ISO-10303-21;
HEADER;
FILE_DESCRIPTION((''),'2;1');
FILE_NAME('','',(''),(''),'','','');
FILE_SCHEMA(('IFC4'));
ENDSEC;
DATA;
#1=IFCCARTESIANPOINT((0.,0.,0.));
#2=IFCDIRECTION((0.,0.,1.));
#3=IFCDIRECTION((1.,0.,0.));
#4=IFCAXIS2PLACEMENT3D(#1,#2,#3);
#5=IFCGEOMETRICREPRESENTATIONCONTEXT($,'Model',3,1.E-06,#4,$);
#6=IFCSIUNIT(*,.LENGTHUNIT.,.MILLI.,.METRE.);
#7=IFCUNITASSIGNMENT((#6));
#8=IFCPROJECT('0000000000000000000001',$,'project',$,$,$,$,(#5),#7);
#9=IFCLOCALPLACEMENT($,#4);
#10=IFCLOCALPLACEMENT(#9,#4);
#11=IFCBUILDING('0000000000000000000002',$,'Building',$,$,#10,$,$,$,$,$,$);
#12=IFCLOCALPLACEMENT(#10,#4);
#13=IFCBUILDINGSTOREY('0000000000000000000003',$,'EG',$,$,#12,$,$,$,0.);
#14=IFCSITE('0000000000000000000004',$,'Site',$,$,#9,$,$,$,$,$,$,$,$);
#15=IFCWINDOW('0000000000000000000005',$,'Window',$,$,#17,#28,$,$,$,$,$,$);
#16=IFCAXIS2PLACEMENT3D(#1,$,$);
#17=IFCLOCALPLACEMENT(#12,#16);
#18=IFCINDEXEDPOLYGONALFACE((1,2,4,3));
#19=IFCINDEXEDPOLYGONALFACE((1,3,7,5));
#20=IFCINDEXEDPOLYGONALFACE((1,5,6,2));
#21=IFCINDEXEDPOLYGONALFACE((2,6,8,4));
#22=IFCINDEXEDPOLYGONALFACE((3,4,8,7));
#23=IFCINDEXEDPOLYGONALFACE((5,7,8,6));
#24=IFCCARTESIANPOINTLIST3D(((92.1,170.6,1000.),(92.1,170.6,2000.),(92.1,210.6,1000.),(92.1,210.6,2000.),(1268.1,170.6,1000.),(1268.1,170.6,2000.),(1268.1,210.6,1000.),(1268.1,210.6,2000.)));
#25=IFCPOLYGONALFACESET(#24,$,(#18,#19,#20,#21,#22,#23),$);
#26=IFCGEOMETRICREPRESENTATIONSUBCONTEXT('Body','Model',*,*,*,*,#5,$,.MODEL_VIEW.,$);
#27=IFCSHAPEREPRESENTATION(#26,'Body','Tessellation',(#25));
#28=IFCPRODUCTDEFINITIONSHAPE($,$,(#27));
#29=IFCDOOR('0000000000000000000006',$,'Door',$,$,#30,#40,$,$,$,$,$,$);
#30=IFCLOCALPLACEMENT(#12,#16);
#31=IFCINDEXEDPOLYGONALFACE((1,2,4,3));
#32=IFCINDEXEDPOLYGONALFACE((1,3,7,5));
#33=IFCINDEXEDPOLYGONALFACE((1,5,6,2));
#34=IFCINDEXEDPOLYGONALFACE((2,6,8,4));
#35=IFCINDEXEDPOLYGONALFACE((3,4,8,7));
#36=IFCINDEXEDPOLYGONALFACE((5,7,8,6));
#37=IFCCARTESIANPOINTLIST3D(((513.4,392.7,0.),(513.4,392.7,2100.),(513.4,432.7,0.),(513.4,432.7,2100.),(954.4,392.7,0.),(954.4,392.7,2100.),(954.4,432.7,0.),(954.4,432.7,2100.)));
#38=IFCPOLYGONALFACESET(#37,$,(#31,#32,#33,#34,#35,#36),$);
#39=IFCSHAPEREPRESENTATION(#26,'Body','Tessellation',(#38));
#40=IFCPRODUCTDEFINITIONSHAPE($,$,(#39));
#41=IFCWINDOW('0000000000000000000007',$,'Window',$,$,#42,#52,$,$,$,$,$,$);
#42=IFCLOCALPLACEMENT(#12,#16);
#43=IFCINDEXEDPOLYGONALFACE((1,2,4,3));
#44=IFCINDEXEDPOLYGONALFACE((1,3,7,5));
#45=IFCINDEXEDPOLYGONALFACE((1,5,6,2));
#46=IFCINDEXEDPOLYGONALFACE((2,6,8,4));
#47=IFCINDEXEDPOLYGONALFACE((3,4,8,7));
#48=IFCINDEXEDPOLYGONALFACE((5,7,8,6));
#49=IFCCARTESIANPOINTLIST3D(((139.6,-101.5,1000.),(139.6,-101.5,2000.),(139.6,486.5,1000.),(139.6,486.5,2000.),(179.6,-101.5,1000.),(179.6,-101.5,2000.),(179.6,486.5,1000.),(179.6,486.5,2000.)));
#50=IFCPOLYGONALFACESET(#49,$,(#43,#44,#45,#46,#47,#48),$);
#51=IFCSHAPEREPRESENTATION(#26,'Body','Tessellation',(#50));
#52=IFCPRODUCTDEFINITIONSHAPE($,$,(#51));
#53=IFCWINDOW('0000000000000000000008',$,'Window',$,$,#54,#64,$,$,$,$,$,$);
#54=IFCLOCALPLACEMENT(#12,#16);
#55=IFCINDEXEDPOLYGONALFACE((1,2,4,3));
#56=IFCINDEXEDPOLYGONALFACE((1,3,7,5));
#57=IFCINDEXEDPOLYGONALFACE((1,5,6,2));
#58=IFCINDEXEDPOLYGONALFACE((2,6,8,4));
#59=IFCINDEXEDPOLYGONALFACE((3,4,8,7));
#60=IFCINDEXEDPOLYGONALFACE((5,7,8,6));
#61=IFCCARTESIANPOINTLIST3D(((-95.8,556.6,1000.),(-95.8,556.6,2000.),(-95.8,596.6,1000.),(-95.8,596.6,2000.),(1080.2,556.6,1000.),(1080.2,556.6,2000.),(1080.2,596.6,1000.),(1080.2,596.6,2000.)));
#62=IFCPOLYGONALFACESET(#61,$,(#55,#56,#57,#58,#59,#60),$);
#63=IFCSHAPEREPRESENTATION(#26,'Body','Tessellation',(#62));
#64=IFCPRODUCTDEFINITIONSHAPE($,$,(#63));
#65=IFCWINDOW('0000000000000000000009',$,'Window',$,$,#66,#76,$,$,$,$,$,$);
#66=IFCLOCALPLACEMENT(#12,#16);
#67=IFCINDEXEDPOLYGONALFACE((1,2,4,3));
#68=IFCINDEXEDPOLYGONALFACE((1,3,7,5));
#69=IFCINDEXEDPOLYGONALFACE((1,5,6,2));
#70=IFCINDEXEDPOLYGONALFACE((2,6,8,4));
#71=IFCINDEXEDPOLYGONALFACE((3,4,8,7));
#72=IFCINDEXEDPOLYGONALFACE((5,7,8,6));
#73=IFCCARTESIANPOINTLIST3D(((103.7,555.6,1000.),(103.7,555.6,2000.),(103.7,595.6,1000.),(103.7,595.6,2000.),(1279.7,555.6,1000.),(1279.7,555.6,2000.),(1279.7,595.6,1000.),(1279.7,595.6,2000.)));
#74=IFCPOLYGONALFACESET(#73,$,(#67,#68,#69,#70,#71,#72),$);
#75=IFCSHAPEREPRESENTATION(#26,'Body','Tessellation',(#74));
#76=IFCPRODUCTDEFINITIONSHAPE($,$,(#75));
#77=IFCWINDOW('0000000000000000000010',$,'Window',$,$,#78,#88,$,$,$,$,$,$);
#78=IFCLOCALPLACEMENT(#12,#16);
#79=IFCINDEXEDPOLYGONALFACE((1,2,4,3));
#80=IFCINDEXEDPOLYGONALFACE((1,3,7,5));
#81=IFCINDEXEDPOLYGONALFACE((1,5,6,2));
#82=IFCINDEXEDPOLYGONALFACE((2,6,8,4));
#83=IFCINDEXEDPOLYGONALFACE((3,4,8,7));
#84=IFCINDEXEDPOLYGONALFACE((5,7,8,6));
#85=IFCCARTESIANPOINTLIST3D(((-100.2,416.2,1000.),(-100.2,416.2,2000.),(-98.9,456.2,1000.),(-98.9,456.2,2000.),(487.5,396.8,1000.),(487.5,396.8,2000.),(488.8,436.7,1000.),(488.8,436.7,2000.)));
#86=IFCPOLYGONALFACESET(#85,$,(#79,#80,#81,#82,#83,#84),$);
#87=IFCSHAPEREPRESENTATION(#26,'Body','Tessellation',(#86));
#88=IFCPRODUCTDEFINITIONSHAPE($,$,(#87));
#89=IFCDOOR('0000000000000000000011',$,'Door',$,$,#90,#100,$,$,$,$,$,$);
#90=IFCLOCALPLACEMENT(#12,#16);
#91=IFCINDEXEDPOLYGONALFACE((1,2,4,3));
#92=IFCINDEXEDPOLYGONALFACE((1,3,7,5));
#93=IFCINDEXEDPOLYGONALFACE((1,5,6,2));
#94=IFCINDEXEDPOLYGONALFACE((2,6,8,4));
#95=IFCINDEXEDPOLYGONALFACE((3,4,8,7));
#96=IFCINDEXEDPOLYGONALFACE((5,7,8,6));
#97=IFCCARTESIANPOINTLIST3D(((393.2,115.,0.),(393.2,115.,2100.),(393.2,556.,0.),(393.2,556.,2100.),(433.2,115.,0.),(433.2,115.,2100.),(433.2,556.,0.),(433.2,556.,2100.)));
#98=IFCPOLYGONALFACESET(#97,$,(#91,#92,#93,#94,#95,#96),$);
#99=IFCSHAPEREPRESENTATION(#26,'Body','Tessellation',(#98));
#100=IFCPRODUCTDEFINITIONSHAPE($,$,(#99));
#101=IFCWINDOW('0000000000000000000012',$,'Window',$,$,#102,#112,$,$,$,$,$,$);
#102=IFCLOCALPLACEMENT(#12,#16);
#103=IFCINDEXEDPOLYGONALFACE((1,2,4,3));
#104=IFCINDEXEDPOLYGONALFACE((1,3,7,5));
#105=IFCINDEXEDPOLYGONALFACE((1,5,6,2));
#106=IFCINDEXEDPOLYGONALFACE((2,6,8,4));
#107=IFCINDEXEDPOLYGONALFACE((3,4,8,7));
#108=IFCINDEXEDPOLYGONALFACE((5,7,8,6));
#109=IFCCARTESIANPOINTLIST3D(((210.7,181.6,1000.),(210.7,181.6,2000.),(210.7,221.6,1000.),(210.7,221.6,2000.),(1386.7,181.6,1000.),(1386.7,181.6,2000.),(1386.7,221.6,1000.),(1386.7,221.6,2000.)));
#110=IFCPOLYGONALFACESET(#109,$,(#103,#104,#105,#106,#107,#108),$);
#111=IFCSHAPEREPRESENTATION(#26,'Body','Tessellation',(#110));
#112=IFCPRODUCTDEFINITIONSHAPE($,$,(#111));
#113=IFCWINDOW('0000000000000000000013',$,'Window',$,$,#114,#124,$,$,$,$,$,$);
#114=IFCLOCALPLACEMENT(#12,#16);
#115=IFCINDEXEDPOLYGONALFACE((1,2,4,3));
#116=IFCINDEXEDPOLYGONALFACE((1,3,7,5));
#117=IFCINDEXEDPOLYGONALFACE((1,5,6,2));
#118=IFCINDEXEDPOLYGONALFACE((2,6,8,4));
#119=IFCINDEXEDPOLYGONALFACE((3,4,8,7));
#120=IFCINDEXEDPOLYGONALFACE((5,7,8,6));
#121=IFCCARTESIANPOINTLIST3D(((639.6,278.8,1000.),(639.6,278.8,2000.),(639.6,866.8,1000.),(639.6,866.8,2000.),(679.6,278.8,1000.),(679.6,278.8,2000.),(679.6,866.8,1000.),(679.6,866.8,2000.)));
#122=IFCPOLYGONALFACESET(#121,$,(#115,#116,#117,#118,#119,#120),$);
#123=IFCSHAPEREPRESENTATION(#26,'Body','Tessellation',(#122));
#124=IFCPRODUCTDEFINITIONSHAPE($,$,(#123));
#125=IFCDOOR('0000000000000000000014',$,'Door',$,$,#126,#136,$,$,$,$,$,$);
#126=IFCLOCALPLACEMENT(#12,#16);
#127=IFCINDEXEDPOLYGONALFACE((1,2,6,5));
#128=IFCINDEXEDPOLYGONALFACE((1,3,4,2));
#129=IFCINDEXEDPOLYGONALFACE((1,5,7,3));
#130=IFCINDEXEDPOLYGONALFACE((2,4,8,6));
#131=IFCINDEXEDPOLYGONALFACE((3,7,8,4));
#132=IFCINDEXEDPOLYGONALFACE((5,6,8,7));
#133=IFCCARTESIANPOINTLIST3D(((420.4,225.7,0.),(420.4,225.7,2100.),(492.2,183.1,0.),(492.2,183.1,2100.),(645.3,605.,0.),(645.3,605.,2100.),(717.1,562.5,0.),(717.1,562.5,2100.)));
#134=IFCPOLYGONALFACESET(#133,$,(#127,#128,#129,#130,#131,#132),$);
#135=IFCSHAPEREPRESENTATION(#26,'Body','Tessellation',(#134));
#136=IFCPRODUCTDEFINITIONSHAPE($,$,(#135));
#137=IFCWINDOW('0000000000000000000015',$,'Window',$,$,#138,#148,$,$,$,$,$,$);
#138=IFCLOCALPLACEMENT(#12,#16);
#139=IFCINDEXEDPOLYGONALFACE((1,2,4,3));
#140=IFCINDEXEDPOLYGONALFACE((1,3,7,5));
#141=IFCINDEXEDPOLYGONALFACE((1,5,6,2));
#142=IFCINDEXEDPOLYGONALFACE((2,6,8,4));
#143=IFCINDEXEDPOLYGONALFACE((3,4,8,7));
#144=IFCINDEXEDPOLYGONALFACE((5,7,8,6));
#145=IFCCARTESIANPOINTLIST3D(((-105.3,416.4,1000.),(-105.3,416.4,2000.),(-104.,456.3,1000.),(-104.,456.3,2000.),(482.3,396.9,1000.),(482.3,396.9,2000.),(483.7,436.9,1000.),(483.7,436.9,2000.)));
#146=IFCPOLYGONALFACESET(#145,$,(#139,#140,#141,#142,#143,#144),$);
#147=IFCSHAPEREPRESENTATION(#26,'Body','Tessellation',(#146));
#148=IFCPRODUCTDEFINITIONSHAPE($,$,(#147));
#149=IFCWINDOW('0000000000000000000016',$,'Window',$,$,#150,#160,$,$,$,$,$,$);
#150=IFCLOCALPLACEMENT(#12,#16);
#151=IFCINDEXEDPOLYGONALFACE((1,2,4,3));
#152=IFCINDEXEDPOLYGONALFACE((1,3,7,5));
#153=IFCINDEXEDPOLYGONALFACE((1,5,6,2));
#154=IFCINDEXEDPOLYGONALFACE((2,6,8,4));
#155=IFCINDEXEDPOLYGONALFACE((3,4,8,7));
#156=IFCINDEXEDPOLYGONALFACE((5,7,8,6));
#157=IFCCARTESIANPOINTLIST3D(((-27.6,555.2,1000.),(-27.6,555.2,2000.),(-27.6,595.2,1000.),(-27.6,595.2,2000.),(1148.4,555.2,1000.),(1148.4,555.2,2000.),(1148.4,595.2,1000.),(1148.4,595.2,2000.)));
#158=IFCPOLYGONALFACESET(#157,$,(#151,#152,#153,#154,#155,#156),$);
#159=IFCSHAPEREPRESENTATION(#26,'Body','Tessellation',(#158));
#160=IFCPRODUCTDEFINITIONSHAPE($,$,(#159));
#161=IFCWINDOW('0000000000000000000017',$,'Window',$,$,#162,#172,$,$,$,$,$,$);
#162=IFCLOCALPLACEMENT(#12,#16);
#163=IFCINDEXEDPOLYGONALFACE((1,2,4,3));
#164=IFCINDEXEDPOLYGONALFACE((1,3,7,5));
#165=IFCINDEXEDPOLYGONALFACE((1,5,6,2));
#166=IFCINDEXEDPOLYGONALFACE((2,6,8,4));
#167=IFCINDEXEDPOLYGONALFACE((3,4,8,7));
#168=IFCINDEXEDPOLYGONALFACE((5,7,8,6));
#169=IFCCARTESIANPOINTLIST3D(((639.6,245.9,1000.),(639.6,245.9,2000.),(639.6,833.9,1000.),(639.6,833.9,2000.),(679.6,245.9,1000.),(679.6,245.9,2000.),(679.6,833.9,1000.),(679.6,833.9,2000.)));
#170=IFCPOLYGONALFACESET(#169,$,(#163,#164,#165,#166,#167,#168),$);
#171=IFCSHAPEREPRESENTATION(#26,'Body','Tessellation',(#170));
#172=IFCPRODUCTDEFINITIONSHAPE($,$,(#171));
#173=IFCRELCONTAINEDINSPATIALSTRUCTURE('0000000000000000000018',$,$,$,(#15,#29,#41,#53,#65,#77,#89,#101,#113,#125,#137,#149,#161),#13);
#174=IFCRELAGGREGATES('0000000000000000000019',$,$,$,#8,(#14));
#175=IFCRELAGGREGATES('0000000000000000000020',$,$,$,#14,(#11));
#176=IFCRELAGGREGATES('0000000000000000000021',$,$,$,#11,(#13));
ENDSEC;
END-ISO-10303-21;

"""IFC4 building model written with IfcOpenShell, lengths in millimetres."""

from ifc_helpers import new_model, si_unit, frame, origin_with_axes, place, context, subcontext, project, spatial, rectangle, extrude, element, save


model = new_model("IFC4")

# Units and contexts
model_context = context("Model", 3, precision=1e-06, world=origin_with_axes())
body_context = subcontext(model_context, "Body", "Model", "MODEL_VIEW")
ifc_project = project(units=[si_unit("LENGTHUNIT", "METRE", prefix="MILLI")], contexts=[model_context])

# Site, building, storey
site_placement = place(None, origin_with_axes())
site = spatial("IfcSite", under=ifc_project, at=site_placement, Name="Site")
building_placement = place(site_placement, origin_with_axes())
building = spatial("IfcBuilding", under=site, at=building_placement, Name="Building")
storey_placement = place(building_placement, origin_with_axes())
storey = spatial("IfcBuildingStorey", under=building, at=storey_placement, Name="EG", Elevation=0.0)

# Window
window_1_placement = place(storey_placement, origin_with_axes())
element("IfcWindow", 1, at=window_1_placement, inside=storey, Name="Window", context=body_context, shape_type="SweptSolid", body=[
    extrude(rectangle(XDim=1176.0, YDim=40.0), frame((680.1, 190.6, 1000.0), z_axis=(0.0, 0.0, 1.0), x_axis=(-1.0, 0.0, 0.0)), (0.0, 0.0, 1.0), 1000.0),
])

# Door
door_1_placement = place(storey_placement, origin_with_axes())
element("IfcDoor", 2, at=door_1_placement, inside=storey, Name="Door", context=body_context, shape_type="SweptSolid", body=[
    extrude(rectangle(XDim=441.0, YDim=40.0), frame((733.9, 412.7, 0.0), z_axis=(0.0, 0.0, 1.0), x_axis=(-1.0, 0.0, 0.0)), (0.0, 0.0, 1.0), 2100.0),
])

# Windows
window_2_placement = place(storey_placement, origin_with_axes())
element("IfcWindow", 3, at=window_2_placement, inside=storey, Name="Window", context=body_context, shape_type="SweptSolid", body=[
    extrude(rectangle(XDim=588.0, YDim=40.0), frame((159.6, 192.5, 1000.0), z_axis=(0.0, 0.0, 1.0), x_axis=(0.0, 1.0, 0.0)), (0.0, 0.0, 1.0), 1000.0),
])
window_3_placement = place(storey_placement, origin_with_axes())
element("IfcWindow", 4, at=window_3_placement, inside=storey, Name="Window", context=body_context, shape_type="SweptSolid", body=[
    extrude(rectangle(XDim=1176.0, YDim=40.0), frame((492.2, 576.6, 1000.0), z_axis=(0.0, 0.0, 1.0), x_axis=(-1.0, 0.0, 0.0)), (0.0, 0.0, 1.0), 1000.0),
])
window_4_placement = place(storey_placement, origin_with_axes())
element("IfcWindow", 5, at=window_4_placement, inside=storey, Name="Window", context=body_context, shape_type="SweptSolid", body=[
    extrude(rectangle(XDim=1176.0, YDim=40.0), frame((691.7, 575.6, 1000.0), z_axis=(0.0, 0.0, 1.0), x_axis=(-1.0, 0.0, 0.0)), (0.0, 0.0, 1.0), 1000.0),
])
window_5_placement = place(storey_placement, origin_with_axes())
element("IfcWindow", 6, at=window_5_placement, inside=storey, Name="Window", context=body_context, shape_type="SweptSolid", body=[
    extrude(rectangle(XDim=588.0, YDim=40.0), frame((194.3, 426.5, 1000.0), z_axis=(0.0, 0.0, 1.0), x_axis=(0.999454, -0.03304, 0.0)), (0.0, 0.0, 1.0), 1000.0),
])

# Door
door_2_placement = place(storey_placement, origin_with_axes())
element("IfcDoor", 7, at=door_2_placement, inside=storey, Name="Door", context=body_context, shape_type="SweptSolid", body=[
    extrude(rectangle(XDim=441.0, YDim=40.0), frame((413.2, 335.5, 0.0), z_axis=(0.0, 0.0, 1.0), x_axis=(0.0, 1.0, 0.0)), (0.0, 0.0, 1.0), 2100.0),
])

# Windows
window_6_placement = place(storey_placement, origin_with_axes())
element("IfcWindow", 8, at=window_6_placement, inside=storey, Name="Window", context=body_context, shape_type="SweptSolid", body=[
    extrude(rectangle(XDim=1176.0, YDim=40.0), frame((798.7, 201.6, 1000.0), z_axis=(0.0, 0.0, 1.0), x_axis=(-1.0, 0.0, 0.0)), (0.0, 0.0, 1.0), 1000.0),
])
window_7_placement = place(storey_placement, origin_with_axes())
element("IfcWindow", 9, at=window_7_placement, inside=storey, Name="Window", context=body_context, shape_type="SweptSolid", body=[
    extrude(rectangle(XDim=588.0, YDim=40.0), frame((659.6, 572.8, 1000.0), z_axis=(0.0, 0.0, 1.0), x_axis=(0.0, 1.0, 0.0)), (0.0, 0.0, 1.0), 1000.0),
])

# Door
door_3_placement = place(storey_placement, origin_with_axes())
element("IfcDoor", 10, at=door_3_placement, inside=storey, Name="Door", context=body_context, shape_type="SweptSolid", body=[
    extrude(rectangle(XDim=441.0, YDim=83.5), frame((568.7, 394.1, 0.0), z_axis=(0.0, 0.0, 1.0), x_axis=(-0.510011, -0.860168, 0.0)), (0.0, 0.0, 1.0), 2100.0),
])

# Windows
window_8_placement = place(storey_placement, origin_with_axes())
element("IfcWindow", 11, at=window_8_placement, inside=storey, Name="Window", context=body_context, shape_type="SweptSolid", body=[
    extrude(rectangle(XDim=588.0, YDim=40.0), frame((189.2, 426.6, 1000.0), z_axis=(0.0, 0.0, 1.0), x_axis=(0.999454, -0.03304, 0.0)), (0.0, 0.0, 1.0), 1000.0),
])
window_9_placement = place(storey_placement, origin_with_axes())
element("IfcWindow", 12, at=window_9_placement, inside=storey, Name="Window", context=body_context, shape_type="SweptSolid", body=[
    extrude(rectangle(XDim=1176.0, YDim=40.0), frame((560.4, 575.2, 1000.0), z_axis=(0.0, 0.0, 1.0), x_axis=(-1.0, 0.0, 0.0)), (0.0, 0.0, 1.0), 1000.0),
])
window_10_placement = place(storey_placement, origin_with_axes())
element("IfcWindow", 13, at=window_10_placement, inside=storey, Name="Window", context=body_context, shape_type="SweptSolid", body=[
    extrude(rectangle(XDim=588.0, YDim=40.0), frame((659.6, 539.9, 1000.0), z_axis=(0.0, 0.0, 1.0), x_axis=(0.0, 1.0, 0.0)), (0.0, 0.0, 1.0), 1000.0),
])

save(model, "model.ifc")
